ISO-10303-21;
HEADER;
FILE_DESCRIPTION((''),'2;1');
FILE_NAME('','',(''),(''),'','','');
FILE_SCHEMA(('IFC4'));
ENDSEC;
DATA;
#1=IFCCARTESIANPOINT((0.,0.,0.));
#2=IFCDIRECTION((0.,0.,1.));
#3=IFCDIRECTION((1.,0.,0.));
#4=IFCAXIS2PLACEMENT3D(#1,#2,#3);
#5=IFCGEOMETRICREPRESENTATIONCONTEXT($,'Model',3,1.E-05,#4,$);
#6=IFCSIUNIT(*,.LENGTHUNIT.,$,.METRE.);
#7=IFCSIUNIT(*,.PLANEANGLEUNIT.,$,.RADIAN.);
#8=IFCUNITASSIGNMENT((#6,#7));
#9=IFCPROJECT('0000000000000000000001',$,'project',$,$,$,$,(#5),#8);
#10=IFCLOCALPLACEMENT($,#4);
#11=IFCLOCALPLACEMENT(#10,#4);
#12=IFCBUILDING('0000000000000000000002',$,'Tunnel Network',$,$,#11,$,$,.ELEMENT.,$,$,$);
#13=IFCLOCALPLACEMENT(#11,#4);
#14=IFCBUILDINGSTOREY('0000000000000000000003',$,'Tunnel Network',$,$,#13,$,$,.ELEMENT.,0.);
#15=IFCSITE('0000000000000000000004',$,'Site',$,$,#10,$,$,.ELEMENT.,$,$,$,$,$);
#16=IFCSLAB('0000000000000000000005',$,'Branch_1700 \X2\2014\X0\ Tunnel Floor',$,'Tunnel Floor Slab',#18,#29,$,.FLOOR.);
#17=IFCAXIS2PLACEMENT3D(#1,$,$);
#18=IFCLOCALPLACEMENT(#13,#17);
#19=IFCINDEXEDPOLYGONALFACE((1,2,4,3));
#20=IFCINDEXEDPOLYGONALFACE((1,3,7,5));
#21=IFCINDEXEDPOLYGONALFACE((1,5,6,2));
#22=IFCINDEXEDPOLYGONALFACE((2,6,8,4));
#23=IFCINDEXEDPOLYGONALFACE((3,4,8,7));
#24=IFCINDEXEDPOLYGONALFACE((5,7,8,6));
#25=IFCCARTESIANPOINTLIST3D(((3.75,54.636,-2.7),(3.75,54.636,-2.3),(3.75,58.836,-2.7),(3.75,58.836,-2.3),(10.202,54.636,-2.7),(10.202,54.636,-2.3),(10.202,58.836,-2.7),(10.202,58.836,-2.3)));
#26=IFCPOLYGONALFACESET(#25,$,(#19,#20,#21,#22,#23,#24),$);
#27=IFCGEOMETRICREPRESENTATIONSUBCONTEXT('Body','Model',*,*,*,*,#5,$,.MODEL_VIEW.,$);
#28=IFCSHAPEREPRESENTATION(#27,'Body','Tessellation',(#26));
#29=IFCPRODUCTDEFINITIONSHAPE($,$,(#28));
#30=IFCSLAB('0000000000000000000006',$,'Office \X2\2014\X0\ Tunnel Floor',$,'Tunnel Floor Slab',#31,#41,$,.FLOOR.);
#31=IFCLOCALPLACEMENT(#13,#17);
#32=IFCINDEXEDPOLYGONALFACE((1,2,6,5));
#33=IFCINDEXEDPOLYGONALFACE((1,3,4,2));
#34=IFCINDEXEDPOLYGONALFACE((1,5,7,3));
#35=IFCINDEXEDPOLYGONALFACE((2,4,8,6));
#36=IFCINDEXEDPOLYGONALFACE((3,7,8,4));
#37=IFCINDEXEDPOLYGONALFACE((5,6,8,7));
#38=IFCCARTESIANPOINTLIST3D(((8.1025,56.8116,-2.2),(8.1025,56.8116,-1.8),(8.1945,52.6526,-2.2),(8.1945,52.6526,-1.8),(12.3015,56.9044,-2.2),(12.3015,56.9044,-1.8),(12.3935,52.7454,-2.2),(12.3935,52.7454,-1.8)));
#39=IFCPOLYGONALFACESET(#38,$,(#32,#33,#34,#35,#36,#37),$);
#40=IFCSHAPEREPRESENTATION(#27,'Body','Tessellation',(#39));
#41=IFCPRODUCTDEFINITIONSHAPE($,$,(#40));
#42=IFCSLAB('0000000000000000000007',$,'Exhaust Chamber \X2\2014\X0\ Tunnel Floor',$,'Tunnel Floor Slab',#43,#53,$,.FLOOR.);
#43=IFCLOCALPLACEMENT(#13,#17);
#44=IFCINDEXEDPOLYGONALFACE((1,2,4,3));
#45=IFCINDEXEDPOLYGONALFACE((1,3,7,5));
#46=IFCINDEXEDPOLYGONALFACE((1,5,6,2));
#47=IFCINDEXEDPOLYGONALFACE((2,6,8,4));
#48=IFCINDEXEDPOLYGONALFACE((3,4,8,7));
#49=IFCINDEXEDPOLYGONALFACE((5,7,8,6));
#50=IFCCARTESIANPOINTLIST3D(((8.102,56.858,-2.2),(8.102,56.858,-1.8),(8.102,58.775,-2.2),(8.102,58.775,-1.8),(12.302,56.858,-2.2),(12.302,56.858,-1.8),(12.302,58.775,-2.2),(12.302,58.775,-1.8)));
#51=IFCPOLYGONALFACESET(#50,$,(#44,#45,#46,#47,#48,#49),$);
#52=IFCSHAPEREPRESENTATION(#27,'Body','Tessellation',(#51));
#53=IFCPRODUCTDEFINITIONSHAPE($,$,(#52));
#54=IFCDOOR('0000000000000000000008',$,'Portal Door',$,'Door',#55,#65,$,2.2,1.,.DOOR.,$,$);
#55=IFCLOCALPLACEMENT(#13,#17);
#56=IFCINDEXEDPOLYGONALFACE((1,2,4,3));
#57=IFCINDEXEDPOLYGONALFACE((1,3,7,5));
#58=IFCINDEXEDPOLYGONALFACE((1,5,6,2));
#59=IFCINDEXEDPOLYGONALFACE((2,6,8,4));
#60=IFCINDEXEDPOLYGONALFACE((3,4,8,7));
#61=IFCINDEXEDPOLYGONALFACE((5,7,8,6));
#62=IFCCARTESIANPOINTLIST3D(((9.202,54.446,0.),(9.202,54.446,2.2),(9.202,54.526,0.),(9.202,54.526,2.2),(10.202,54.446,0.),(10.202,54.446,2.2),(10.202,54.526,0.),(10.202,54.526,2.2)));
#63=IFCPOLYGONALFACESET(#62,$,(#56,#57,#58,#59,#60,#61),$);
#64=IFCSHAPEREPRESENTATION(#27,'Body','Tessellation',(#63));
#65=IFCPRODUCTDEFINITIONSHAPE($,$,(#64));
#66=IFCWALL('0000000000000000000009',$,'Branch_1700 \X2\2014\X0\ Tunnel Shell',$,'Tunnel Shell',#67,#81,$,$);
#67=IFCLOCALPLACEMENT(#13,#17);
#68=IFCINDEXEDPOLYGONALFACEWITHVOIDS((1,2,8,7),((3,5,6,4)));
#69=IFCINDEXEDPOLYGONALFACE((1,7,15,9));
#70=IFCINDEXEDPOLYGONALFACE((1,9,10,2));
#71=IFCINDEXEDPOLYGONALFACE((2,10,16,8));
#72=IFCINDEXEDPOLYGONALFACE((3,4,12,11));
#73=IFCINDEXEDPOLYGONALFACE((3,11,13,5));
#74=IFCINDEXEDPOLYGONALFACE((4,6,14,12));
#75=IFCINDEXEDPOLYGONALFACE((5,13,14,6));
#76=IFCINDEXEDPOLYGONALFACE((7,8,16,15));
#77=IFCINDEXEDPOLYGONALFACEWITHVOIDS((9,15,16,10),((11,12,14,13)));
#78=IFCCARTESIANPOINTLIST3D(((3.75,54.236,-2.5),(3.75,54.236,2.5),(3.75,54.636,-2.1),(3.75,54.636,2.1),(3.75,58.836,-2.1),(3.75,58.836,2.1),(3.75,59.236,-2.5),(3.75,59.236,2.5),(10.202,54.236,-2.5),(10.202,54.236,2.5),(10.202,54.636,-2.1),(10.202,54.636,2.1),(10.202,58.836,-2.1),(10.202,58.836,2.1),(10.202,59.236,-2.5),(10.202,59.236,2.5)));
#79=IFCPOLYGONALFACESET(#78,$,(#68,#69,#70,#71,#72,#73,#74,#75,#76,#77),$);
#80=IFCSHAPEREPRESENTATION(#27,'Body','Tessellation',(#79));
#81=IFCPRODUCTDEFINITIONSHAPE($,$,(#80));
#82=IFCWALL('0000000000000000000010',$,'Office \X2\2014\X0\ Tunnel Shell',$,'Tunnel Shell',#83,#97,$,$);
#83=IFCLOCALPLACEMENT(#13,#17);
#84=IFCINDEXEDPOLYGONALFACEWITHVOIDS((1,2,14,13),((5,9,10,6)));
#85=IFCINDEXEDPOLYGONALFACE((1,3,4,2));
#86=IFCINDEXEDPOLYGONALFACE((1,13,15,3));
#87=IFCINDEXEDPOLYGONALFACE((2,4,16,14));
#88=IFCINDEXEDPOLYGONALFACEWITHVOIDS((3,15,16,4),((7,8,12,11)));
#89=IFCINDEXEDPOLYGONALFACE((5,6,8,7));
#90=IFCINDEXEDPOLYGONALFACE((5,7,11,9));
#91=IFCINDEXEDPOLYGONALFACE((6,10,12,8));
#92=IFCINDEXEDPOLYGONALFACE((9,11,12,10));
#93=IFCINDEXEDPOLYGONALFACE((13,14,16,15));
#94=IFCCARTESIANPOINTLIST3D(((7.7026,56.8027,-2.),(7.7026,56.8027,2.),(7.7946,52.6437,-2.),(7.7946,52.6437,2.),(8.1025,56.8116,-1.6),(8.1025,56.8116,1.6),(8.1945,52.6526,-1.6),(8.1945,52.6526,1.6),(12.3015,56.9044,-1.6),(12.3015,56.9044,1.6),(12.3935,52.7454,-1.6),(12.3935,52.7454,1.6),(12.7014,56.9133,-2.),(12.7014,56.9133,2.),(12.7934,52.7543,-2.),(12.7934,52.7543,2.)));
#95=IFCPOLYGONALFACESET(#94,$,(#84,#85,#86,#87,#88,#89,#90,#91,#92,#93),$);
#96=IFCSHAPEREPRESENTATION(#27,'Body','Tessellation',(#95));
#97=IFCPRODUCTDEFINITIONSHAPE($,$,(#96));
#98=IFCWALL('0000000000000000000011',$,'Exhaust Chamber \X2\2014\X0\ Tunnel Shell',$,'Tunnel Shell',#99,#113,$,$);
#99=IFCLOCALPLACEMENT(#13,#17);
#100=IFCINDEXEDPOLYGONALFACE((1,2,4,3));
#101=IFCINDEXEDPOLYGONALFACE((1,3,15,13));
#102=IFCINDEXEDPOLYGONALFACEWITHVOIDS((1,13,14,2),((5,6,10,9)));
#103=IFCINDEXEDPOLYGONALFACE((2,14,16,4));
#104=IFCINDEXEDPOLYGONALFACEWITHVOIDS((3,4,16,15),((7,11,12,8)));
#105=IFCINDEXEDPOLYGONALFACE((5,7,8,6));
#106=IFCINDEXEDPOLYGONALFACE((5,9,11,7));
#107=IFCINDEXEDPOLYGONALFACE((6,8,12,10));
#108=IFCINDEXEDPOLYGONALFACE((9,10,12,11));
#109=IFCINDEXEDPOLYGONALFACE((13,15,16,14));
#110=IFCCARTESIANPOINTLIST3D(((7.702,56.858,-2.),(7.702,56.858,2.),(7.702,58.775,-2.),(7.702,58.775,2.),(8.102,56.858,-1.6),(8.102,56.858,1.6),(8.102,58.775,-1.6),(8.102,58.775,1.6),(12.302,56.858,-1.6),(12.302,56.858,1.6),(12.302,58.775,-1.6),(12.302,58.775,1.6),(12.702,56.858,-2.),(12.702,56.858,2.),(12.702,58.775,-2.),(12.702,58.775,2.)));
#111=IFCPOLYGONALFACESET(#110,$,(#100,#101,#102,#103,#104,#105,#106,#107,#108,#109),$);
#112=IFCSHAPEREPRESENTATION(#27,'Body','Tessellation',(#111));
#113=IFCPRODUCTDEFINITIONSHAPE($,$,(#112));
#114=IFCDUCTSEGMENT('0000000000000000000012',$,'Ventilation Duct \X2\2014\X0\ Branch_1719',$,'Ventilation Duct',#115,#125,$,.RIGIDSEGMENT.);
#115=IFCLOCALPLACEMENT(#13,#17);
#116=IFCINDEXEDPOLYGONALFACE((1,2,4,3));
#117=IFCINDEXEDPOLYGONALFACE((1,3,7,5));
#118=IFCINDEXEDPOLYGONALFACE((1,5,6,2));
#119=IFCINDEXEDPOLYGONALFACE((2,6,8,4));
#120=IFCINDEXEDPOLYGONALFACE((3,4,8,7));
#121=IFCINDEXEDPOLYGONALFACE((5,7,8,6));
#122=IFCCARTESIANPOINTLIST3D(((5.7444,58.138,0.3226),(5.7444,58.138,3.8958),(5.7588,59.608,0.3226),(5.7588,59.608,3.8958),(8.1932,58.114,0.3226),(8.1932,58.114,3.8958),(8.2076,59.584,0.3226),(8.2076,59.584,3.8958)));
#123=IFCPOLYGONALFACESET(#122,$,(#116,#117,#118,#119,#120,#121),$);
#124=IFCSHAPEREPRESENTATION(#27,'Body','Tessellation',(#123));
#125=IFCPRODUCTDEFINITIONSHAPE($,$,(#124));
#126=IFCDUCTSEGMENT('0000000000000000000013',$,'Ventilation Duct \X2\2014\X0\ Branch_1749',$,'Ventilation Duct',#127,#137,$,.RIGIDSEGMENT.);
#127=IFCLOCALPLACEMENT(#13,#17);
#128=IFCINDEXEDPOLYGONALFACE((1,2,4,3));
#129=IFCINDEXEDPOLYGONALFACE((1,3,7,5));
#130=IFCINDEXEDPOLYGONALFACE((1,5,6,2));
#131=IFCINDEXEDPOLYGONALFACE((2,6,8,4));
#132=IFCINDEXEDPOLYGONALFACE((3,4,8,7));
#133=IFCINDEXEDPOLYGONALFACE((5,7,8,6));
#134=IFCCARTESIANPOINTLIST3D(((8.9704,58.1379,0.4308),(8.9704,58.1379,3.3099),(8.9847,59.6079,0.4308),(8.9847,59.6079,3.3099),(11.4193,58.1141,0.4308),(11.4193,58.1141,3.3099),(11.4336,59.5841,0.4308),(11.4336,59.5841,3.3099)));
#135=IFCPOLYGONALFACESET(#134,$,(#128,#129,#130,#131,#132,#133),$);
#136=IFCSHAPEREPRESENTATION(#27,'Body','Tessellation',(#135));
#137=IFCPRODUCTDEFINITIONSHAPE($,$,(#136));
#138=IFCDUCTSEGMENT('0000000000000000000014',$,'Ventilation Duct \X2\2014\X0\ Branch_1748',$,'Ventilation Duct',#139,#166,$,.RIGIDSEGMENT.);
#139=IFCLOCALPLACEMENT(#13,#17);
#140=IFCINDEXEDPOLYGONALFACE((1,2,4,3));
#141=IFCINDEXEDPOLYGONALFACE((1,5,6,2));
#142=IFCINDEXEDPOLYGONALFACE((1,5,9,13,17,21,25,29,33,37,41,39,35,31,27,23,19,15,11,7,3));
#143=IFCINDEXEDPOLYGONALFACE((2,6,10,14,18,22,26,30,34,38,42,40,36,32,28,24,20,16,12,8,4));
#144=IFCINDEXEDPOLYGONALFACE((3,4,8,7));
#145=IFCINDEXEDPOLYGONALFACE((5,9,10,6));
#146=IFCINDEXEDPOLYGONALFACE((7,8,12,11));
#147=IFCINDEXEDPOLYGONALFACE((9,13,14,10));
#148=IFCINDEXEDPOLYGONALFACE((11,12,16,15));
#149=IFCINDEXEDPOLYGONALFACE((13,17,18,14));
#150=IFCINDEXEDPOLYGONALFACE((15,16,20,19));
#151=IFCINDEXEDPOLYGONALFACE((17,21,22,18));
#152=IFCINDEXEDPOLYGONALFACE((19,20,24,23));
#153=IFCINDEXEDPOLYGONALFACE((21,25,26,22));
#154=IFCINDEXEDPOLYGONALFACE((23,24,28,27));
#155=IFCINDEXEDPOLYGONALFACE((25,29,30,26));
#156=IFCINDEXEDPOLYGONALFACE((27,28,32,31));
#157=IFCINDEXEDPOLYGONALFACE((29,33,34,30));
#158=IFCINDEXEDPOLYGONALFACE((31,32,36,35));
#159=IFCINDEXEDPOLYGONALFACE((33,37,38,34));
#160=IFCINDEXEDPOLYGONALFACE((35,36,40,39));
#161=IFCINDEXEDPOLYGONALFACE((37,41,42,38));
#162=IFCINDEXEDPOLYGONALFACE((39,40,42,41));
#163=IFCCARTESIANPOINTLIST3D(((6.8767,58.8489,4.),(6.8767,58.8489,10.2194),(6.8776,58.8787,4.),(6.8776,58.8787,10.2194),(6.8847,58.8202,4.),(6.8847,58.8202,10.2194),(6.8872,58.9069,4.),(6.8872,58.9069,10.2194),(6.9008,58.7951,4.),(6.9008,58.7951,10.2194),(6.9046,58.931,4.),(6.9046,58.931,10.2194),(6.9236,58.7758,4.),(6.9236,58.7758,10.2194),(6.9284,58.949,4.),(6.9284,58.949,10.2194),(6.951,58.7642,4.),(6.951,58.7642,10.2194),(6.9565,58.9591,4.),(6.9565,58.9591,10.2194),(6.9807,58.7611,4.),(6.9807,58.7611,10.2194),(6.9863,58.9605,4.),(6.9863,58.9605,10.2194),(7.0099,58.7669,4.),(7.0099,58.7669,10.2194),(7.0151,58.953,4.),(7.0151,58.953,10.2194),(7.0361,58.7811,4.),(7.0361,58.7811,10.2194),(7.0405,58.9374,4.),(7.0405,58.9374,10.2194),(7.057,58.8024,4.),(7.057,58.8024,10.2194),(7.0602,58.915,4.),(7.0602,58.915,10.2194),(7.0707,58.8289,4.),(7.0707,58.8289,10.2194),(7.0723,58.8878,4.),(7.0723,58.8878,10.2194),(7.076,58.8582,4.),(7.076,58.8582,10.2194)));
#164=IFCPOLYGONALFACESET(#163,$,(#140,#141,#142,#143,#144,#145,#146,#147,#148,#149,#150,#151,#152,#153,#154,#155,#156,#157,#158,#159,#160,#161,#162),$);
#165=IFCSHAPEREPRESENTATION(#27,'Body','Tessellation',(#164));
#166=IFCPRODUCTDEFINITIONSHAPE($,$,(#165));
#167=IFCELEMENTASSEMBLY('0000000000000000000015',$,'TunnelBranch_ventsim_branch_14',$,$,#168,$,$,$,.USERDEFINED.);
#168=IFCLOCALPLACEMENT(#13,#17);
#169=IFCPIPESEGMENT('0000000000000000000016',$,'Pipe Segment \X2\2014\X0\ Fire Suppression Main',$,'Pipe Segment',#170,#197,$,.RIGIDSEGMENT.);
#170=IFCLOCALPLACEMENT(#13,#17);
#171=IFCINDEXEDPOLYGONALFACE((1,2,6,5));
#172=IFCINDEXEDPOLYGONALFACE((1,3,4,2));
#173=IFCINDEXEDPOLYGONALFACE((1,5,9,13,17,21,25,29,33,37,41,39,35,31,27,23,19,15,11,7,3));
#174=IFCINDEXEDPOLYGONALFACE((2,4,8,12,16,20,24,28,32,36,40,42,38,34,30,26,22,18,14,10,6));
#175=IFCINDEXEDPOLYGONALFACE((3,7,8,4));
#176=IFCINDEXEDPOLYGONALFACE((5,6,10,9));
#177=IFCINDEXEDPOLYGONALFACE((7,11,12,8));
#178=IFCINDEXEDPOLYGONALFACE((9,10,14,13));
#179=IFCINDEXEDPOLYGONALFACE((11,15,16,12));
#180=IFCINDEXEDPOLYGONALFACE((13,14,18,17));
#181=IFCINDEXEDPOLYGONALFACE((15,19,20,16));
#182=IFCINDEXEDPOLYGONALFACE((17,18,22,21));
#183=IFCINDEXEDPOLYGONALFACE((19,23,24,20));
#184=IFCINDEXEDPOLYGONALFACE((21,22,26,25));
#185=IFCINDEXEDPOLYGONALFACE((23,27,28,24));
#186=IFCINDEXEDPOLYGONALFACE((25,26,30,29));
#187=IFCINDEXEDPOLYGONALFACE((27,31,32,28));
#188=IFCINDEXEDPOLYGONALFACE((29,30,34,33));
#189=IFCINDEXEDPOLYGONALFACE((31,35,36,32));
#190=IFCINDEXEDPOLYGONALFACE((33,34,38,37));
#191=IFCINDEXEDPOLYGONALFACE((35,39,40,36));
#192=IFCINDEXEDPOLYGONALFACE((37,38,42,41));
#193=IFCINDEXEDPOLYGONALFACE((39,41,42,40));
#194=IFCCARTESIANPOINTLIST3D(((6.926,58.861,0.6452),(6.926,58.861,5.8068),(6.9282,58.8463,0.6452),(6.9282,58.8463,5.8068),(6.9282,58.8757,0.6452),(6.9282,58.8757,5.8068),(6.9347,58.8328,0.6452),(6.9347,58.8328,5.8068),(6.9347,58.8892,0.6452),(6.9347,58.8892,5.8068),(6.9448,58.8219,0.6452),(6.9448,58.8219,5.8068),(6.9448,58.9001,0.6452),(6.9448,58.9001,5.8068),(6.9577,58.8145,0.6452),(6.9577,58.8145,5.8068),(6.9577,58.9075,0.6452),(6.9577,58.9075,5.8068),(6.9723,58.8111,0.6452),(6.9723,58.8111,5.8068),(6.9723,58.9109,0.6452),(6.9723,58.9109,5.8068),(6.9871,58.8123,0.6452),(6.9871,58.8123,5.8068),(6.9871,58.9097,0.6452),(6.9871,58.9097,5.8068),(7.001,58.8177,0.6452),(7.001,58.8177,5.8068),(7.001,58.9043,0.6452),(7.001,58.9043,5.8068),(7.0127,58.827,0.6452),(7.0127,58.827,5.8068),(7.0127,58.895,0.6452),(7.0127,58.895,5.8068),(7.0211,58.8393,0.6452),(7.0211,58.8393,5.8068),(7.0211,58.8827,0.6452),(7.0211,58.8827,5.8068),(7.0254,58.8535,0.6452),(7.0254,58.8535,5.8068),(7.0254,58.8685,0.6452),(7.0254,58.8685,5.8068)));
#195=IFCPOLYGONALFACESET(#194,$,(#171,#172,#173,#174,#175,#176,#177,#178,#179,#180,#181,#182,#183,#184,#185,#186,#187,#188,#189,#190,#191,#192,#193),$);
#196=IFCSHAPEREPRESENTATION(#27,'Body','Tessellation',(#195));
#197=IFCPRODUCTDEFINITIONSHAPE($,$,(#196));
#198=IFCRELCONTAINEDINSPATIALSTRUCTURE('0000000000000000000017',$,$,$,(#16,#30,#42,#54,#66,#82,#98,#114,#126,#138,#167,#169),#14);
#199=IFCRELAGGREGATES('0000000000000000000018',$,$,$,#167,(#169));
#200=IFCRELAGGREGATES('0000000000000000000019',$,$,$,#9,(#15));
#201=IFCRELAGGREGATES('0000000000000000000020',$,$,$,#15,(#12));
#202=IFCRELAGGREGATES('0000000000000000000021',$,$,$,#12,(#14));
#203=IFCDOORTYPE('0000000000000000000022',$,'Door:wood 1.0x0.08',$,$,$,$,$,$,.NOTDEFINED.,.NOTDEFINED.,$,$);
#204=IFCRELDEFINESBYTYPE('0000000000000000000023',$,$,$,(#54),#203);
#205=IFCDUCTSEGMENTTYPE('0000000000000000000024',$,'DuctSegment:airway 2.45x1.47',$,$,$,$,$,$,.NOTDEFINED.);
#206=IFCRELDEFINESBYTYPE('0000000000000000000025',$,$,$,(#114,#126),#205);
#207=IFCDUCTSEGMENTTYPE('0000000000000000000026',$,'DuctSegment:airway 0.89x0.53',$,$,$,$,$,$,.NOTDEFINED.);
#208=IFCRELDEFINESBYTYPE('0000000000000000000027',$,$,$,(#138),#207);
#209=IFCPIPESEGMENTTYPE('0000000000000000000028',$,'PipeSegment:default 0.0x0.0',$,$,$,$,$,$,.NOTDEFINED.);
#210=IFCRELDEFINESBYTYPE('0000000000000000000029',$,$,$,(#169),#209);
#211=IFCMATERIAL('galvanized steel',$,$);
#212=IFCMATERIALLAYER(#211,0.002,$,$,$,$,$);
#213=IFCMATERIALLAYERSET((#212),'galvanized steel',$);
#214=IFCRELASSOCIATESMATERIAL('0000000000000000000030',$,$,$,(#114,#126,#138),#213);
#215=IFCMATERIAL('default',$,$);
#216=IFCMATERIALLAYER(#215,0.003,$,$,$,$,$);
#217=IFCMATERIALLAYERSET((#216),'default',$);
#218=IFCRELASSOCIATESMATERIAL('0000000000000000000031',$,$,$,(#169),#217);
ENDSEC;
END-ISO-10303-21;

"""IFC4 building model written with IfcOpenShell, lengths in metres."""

from ifc_helpers import new_model, entity, si_unit, frame, origin_with_axes, origin_2d_with_axis, place, context, subcontext, project, spatial, rectangle, hollow_rectangle, circle, extrude, material, layer, layer_set, layer_usage, type_object, element, aggregate, save


model = new_model("IFC4")

# Units and contexts
model_context = context("Model", 3, precision=1e-05, world=origin_with_axes())
body_context = subcontext(model_context, "Body", "Model", "MODEL_VIEW")
ifc_project = project(units=[si_unit("LENGTHUNIT", "METRE"), si_unit("PLANEANGLEUNIT", "RADIAN")], contexts=[model_context])

# Site, building, storey
site_placement = place(None, origin_with_axes())
site = spatial("IfcSite", under=ifc_project, at=site_placement, Name="Site", CompositionType="ELEMENT")
building_placement = place(site_placement, origin_with_axes())
building = spatial("IfcBuilding", under=site, at=building_placement, Name="Tunnel Network", CompositionType="ELEMENT")
storey_placement = place(building_placement, origin_with_axes())
storey = spatial("IfcBuildingStorey", under=building, at=storey_placement, Name="Tunnel Network", CompositionType="ELEMENT", Elevation=0.0)

# Slabs
placement_1 = place(storey_placement, frame((10.202, 56.736, 0.0), z_axis=(0.0, 0.0, 1.0), x_axis=(-1.0, 0.0, 0.0)))
element("IfcSlab", 1, at=placement_1, inside=storey, Name="Branch_1700 — Tunnel Floor", ObjectType="Tunnel Floor Slab", PredefinedType="FLOOR", context=body_context, shape_type="SweptSolid", body=[
    extrude(rectangle(XDim=0.4, YDim=4.2, at=origin_2d_with_axis()), frame((0.0, 0.0, -2.5), z_axis=(1.0, 0.0, 0.0), x_axis=(0.0, 0.0, 1.0)), (0.0, 0.0, 1.0), 6.452),
])
placement_2 = place(storey_placement, frame((10.202, 56.858, 0.0), z_axis=(0.0, 0.0, 1.0), x_axis=(0.022115, -0.999755, 0.0)))
element("IfcSlab", 2, at=placement_2, inside=storey, Name="Office — Tunnel Floor", ObjectType="Tunnel Floor Slab", PredefinedType="FLOOR", context=body_context, shape_type="SweptSolid", body=[
    extrude(rectangle(XDim=0.4, YDim=4.2, at=origin_2d_with_axis()), frame((0.0, 0.0, -2.0), z_axis=(1.0, 0.0, 0.0), x_axis=(0.0, 0.0, 1.0)), (0.0, 0.0, 1.0), 4.16),
])
placement_3 = place(storey_placement, frame((10.202, 56.858, 0.0), z_axis=(0.0, 0.0, 1.0), x_axis=(0.0, 1.0, 0.0)))
element("IfcSlab", 3, at=placement_3, inside=storey, Name="Exhaust Chamber — Tunnel Floor", ObjectType="Tunnel Floor Slab", PredefinedType="FLOOR", context=body_context, shape_type="SweptSolid", body=[
    extrude(rectangle(XDim=0.4, YDim=4.2, at=origin_2d_with_axis()), frame((0.0, 0.0, -2.0), z_axis=(1.0, 0.0, 0.0), x_axis=(0.0, 0.0, 1.0)), (0.0, 0.0, 1.0), 1.917),
])

# Door
door_type = type_object("IfcDoorType", Name="Door:wood 1.0x0.08")
door_placement = place(storey_placement, frame((9.702, 54.486, 0.0), z_axis=(0.0, 0.0, 1.0), x_axis=(1.0, 0.0, 0.0)))
element("IfcDoor", 4, at=door_placement, inside=storey, type_object=door_type, Name="Portal Door", ObjectType="Door", OverallHeight=2.2, OverallWidth=1.0, PredefinedType="DOOR", context=body_context, shape_type="SweptSolid", body=[
    extrude(rectangle(XDim=1.0, YDim=0.08, at=origin_2d_with_axis()), origin_with_axes(), (0.0, 0.0, 1.0), 2.2),
])

# Walls
element("IfcWall", 5, at=placement_1, inside=storey, Name="Branch_1700 — Tunnel Shell", ObjectType="Tunnel Shell", context=body_context, shape_type="SweptSolid", body=[
    extrude(hollow_rectangle(XDim=5.0, YDim=5.0, WallThickness=0.4, at=origin_2d_with_axis()), frame((0.0, 0.0, 0.0), z_axis=(1.0, 0.0, 0.0), x_axis=(0.0, 0.0, 1.0)), (0.0, 0.0, 1.0), 6.452),
])
element("IfcWall", 6, at=placement_2, inside=storey, Name="Office — Tunnel Shell", ObjectType="Tunnel Shell", context=body_context, shape_type="SweptSolid", body=[
    extrude(hollow_rectangle(XDim=4.0, YDim=5.0, WallThickness=0.4, at=origin_2d_with_axis()), frame((0.0, 0.0, 0.0), z_axis=(1.0, 0.0, 0.0), x_axis=(0.0, 0.0, 1.0)), (0.0, 0.0, 1.0), 4.16),
])
element("IfcWall", 7, at=placement_3, inside=storey, Name="Exhaust Chamber — Tunnel Shell", ObjectType="Tunnel Shell", context=body_context, shape_type="SweptSolid", body=[
    extrude(hollow_rectangle(XDim=4.0, YDim=5.0, WallThickness=0.4, at=origin_2d_with_axis()), frame((0.0, 0.0, 0.0), z_axis=(1.0, 0.0, 0.0), x_axis=(0.0, 0.0, 1.0)), (0.0, 0.0, 1.0), 1.917),
])

# Duct segments
ifc_material_1 = material(Name="galvanized steel")
ifc_layer_1 = layer(ifc_material_1, 0.002)
ifc_layer_set_1 = layer_set([ifc_layer_1], Name="galvanized steel")
ifc_layer_usage_1 = layer_usage(ifc_layer_set_1, "AXIS2", "POSITIVE", 0.0)
duct_segment_type_1 = type_object("IfcDuctSegmentType", Name="DuctSegment:airway 2.45x1.47")
duct_segment_1_placement = place(storey_placement, frame((6.976, 58.861, 0.3226), z_axis=(0.0, 0.0, 1.0), x_axis=(0.999952, -0.009795, 0.0)))
element("IfcDuctSegment", 8, at=duct_segment_1_placement, inside=storey, type_object=duct_segment_type_1, material=ifc_layer_usage_1, Name="Ventilation Duct — Branch_1719", ObjectType="Ventilation Duct", PredefinedType="RIGIDSEGMENT", context=body_context, shape_type="SweptSolid", body=[
    extrude(rectangle(XDim=2.449, YDim=1.47, at=origin_2d_with_axis()), origin_with_axes(), (0.0, 0.0, 1.0), 3.5732),
])
ifc_layer_usage_2 = layer_usage(ifc_layer_set_1, "AXIS2", "POSITIVE", 0.0)
duct_segment_2_placement = place(storey_placement, frame((10.202, 58.861, 0.4308), z_axis=(0.0, 0.0, 1.0), x_axis=(0.999953, -0.009725, 0.0)))
element("IfcDuctSegment", 9, at=duct_segment_2_placement, inside=storey, type_object=duct_segment_type_1, material=ifc_layer_usage_2, Name="Ventilation Duct — Branch_1749", ObjectType="Ventilation Duct", PredefinedType="RIGIDSEGMENT", context=body_context, shape_type="SweptSolid", body=[
    extrude(rectangle(XDim=2.449, YDim=1.47, at=origin_2d_with_axis()), origin_with_axes(), (0.0, 0.0, 1.0), 2.8791),
])
ifc_layer_usage_3 = layer_usage(ifc_layer_set_1, "AXIS2", "POSITIVE", 0.0)
duct_segment_type_2 = type_object("IfcDuctSegmentType", Name="DuctSegment:airway 0.89x0.53")
duct_segment_3_placement = place(storey_placement, frame((6.976, 58.861, 4.0), z_axis=(0.0, 0.0, 1.0), x_axis=(0.999609, -0.027977, 0.0)))
element("IfcDuctSegment", 10, at=duct_segment_3_placement, inside=storey, type_object=duct_segment_type_2, material=ifc_layer_usage_3, Name="Ventilation Duct — Branch_1748", ObjectType="Ventilation Duct", PredefinedType="RIGIDSEGMENT", context=body_context, shape_type="AdvancedSweptSolid", body=[
    entity("IfcSweptDiskSolid", entity("IfcPolyline", [entity("IfcCartesianPoint", [0.0, 0.0, 0.0]), entity("IfcCartesianPoint", [0.0, 0.0, 6.2194])]), 0.1),
])

# Element assembly, pipe segment
assembly_1_placement = place(storey_placement, frame((6.976, 58.861, 1.25), z_axis=(0.0, 1.0, 0.0), x_axis=(-1.0, 0.0, 0.0)))
assembly_1 = element("IfcElementAssembly", 11, at=assembly_1_placement, inside=storey, Name="TunnelBranch_ventsim_branch_14", PredefinedType="USERDEFINED")
ifc_material_2 = material(Name="default")
ifc_layer_2 = layer(ifc_material_2, 0.003)
ifc_layer_set_2 = layer_set([ifc_layer_2], Name="default")
ifc_layer_usage_4 = layer_usage(ifc_layer_set_2, "AXIS2", "POSITIVE", 0.0)
pipe_segment_type = type_object("IfcPipeSegmentType", Name="PipeSegment:default 0.0x0.0")
pipe_segment_placement = place(storey_placement, frame((6.976, 58.861, 0.6452), z_axis=(0.0, 0.0, 1.0), x_axis=(-1.0, 0.0, 0.0)))
pipe_segment = element("IfcPipeSegment", 12, at=pipe_segment_placement, inside=storey, type_object=pipe_segment_type, material=ifc_layer_usage_4, Name="Pipe Segment — Fire Suppression Main", ObjectType="Pipe Segment", PredefinedType="RIGIDSEGMENT", context=body_context, shape_type="SweptSolid", body=[
    extrude(circle(Radius=0.05, at=origin_2d_with_axis()), origin_with_axes(), (0.0, 0.0, 1.0), 5.1616),
])

aggregate(assembly_1, [pipe_segment])

save(model, "model.ifc")
